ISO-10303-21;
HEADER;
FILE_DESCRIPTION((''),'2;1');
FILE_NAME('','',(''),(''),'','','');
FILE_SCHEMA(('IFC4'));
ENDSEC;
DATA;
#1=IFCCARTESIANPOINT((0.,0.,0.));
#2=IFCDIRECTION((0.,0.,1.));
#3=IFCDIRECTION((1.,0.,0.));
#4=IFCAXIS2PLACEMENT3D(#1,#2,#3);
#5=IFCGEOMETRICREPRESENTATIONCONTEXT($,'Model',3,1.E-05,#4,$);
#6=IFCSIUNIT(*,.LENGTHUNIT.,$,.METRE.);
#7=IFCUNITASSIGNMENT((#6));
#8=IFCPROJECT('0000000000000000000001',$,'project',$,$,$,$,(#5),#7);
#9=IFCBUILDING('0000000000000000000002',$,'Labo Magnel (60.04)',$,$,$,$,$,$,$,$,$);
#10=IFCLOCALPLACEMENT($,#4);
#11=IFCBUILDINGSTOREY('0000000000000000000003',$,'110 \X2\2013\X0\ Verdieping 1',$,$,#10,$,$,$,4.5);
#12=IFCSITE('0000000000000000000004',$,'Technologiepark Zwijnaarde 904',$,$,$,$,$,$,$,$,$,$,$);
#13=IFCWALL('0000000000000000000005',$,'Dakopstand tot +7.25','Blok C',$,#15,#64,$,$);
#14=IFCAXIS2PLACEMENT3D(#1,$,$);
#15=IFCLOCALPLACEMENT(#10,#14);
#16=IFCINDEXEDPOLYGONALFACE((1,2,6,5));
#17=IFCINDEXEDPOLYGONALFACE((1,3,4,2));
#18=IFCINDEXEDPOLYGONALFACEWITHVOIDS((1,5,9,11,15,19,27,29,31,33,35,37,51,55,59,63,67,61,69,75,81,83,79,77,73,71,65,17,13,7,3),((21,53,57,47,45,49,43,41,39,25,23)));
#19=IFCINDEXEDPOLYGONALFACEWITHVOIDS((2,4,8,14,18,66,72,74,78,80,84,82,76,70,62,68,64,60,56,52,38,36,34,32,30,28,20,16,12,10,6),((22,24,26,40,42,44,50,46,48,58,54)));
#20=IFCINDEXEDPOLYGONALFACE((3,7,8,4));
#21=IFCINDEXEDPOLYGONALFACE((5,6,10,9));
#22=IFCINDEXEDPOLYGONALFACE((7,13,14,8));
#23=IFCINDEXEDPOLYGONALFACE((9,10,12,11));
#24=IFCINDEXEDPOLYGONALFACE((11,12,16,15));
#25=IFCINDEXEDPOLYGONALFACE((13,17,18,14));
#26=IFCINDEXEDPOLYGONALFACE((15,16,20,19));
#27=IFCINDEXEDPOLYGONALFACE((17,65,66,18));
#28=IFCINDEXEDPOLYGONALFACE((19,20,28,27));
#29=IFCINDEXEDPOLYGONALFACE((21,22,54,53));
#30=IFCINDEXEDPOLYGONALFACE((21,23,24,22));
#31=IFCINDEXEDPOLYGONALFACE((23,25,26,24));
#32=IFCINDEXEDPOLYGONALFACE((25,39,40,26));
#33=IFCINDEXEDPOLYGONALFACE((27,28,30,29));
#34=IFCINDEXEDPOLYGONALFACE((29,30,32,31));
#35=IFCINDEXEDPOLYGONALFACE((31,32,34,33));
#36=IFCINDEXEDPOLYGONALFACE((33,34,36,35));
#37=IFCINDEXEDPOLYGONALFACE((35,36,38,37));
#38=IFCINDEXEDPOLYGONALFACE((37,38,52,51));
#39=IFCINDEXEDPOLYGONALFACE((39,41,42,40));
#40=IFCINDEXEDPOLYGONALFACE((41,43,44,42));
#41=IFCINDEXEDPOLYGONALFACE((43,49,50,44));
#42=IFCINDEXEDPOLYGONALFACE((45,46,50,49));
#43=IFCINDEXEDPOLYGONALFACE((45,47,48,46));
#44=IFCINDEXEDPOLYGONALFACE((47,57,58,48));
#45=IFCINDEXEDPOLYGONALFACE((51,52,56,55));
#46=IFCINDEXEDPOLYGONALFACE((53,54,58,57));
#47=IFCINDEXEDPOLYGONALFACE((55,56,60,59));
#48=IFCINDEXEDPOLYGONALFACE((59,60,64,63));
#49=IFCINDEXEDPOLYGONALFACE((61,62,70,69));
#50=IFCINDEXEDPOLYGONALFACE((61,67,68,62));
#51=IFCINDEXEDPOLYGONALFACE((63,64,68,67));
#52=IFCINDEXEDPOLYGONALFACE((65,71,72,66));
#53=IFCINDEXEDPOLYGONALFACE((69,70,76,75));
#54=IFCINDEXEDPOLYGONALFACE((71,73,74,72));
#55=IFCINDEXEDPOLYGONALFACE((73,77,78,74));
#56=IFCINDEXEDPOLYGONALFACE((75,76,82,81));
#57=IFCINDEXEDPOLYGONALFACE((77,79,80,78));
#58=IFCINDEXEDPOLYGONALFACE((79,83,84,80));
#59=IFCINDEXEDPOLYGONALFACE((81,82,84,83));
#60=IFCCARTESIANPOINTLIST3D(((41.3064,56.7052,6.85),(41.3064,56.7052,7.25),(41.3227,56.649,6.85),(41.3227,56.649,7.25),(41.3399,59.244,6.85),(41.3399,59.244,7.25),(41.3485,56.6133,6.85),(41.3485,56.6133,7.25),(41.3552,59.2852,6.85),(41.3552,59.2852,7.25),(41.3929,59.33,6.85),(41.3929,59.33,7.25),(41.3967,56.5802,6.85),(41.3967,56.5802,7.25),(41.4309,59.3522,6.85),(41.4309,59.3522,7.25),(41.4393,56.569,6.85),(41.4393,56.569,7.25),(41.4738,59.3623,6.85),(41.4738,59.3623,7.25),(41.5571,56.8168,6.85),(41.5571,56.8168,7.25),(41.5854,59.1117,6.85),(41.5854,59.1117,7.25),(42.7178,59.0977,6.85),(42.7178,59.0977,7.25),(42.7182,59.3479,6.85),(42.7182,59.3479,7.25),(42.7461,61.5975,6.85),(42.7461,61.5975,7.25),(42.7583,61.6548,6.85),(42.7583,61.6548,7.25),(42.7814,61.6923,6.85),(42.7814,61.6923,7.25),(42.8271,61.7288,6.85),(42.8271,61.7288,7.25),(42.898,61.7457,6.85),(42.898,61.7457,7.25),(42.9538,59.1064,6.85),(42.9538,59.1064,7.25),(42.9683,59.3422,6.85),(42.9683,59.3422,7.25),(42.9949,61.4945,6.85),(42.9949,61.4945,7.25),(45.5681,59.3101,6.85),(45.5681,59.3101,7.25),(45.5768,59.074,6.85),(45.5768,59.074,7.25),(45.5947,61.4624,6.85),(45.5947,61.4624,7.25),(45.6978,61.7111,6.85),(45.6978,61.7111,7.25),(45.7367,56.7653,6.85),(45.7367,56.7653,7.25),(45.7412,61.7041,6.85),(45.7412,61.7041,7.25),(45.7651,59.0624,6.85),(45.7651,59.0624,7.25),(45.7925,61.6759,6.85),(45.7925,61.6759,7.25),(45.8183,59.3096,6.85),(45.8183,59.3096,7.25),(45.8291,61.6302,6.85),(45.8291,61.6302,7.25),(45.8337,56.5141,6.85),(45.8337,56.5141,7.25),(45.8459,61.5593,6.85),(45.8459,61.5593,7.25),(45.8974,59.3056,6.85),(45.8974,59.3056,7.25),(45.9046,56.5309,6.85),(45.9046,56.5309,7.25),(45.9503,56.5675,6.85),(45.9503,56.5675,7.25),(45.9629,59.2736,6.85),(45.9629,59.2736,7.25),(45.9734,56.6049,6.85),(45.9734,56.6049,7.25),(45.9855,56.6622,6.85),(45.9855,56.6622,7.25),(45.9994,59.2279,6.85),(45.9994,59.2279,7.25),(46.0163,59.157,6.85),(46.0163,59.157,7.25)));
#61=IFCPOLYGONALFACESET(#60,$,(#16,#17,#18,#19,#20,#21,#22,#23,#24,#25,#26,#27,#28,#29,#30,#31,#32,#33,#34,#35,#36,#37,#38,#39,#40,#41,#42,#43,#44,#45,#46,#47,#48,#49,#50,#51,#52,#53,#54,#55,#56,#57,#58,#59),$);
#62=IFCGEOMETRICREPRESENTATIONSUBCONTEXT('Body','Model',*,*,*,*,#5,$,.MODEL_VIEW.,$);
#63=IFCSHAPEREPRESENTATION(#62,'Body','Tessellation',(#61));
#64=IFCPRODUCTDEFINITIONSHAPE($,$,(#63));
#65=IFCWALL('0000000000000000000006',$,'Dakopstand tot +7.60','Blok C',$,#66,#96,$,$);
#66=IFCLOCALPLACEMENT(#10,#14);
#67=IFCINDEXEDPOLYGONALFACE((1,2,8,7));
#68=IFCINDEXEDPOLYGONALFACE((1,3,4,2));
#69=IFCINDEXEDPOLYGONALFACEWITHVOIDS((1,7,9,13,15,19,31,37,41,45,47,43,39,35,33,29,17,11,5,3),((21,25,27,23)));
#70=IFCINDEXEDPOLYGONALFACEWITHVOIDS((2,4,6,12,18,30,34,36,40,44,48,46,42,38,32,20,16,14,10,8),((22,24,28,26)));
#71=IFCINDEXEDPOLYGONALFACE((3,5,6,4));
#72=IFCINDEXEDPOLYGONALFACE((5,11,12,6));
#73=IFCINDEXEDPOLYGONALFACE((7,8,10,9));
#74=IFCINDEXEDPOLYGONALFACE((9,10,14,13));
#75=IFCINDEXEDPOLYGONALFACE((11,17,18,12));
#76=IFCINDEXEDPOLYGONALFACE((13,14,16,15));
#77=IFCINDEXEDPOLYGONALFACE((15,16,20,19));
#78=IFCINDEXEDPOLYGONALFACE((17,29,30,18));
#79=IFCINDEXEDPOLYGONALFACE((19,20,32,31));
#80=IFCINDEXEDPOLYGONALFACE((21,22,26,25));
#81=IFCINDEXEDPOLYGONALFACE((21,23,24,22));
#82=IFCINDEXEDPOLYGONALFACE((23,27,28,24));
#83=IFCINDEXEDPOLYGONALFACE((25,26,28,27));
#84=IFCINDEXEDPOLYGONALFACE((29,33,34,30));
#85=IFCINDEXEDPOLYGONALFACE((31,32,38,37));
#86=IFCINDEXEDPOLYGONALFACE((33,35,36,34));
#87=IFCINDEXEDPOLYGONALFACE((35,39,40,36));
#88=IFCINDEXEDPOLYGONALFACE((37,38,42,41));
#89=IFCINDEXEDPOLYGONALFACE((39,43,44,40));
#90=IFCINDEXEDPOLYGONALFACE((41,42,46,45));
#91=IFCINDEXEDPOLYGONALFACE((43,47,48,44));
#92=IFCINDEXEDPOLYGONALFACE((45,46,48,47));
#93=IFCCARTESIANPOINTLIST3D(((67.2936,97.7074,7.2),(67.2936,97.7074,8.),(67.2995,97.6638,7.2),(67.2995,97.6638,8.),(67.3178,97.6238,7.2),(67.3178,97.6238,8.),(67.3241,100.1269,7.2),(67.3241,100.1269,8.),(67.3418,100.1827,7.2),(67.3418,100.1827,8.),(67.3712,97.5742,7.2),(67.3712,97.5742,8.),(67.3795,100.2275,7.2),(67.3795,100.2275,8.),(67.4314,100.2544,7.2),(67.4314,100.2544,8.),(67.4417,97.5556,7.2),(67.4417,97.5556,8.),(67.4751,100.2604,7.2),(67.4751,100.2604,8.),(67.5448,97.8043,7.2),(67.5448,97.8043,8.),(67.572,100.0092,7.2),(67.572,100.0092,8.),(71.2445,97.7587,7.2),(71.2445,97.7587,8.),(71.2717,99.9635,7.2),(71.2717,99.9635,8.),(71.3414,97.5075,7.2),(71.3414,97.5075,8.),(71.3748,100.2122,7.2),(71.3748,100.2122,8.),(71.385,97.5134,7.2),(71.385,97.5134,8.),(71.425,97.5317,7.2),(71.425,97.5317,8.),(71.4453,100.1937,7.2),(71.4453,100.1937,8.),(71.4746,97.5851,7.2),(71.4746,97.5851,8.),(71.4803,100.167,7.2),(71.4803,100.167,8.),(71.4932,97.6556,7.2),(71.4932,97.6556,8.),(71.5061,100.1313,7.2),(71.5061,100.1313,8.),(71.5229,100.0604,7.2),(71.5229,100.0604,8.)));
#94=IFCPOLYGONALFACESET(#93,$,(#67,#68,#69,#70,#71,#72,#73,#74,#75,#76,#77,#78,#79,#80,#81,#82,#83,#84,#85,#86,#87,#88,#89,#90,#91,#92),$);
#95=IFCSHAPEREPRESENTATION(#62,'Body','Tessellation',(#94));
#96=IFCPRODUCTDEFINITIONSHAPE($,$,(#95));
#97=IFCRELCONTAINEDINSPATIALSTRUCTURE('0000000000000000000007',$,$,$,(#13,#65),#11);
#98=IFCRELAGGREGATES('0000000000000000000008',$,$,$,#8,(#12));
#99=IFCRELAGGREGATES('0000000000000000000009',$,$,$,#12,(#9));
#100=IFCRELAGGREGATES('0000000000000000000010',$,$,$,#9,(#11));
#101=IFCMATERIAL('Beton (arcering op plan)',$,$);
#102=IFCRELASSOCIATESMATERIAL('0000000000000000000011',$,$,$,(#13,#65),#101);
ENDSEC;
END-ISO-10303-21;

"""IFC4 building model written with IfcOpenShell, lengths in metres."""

from ifc_helpers import new_model, si_unit, frame, origin, origin_with_axes, place, context, subcontext, project, spatial, polyline, outline, extrude, material, element, save


model = new_model("IFC4")

# Units and contexts
model_context = context("Model", 3, precision=1e-05, world=origin_with_axes())
body_context = subcontext(model_context, "Body", "Model", "MODEL_VIEW")
ifc_project = project(units=[si_unit("LENGTHUNIT", "METRE")], contexts=[model_context])

# Site, building, storey
site = spatial("IfcSite", under=ifc_project, Name="Technologiepark Zwijnaarde 904")
building = spatial("IfcBuilding", under=site, Name="Labo Magnel (60.04)")
storey_placement = place(None, origin_with_axes())
storey = spatial("IfcBuildingStorey", under=building, at=storey_placement, Name="110 – Verdieping 1", Elevation=4.5)

# Shared definitions
ifc_material_1 = material(Name="Beton (arcering op plan)")

# Walls
wall_1_placement = place(storey_placement, frame((0.0, 0.0, 6.85), z_axis=(0.0, 0.0, 1.0), x_axis=(1.0, 0.0, 0.0)))
element("IfcWall", 1, at=wall_1_placement, inside=storey, material=ifc_material_1, Name="Dakopstand tot +7.25", Description="Blok C", context=body_context, shape_type="SweptSolid", body=[
    extrude(outline(polyline([(41.4393, 56.569), (41.3967, 56.5802), (41.3485, 56.6133), (41.3227, 56.649), (41.3064, 56.7052), (41.3399, 59.244), (41.3552, 59.2852), (41.3929, 59.33), (41.4309, 59.3522), (41.4738, 59.3623), (42.7182, 59.3479), (42.7461, 61.5975), (42.7583, 61.6548), (42.7814, 61.6923), (42.8271, 61.7288), (42.898, 61.7457), (45.6978, 61.7111), (45.7412, 61.7041), (45.7925, 61.6759), (45.8291, 61.6302), (45.8459, 61.5593), (45.8183, 59.3096), (45.8974, 59.3056), (45.9629, 59.2736), (45.9994, 59.2279), (46.0163, 59.157), (45.9855, 56.6622), (45.9734, 56.6049), (45.9503, 56.5675), (45.9046, 56.5309), (45.8337, 56.5141), (41.4393, 56.569)]), holes=[polyline([(41.5571, 56.8168), (45.7367, 56.7653), (45.7651, 59.0624), (45.5768, 59.074), (45.5681, 59.3101), (45.5947, 61.4624), (42.9949, 61.4945), (42.9683, 59.3422), (42.9538, 59.1064), (42.7178, 59.0977), (41.5854, 59.1117), (41.5571, 56.8168)])]), origin(), (0.0, 0.0, 1.0), 0.4),
])
wall_2_placement = place(storey_placement, frame((0.0, 0.0, 7.2), z_axis=(0.0, 0.0, 1.0), x_axis=(1.0, 0.0, 0.0)))
element("IfcWall", 2, at=wall_2_placement, inside=storey, material=ifc_material_1, Name="Dakopstand tot +7.60", Description="Blok C", context=body_context, shape_type="SweptSolid", body=[
    extrude(outline(polyline([(67.3241, 100.1269), (67.3418, 100.1827), (67.3795, 100.2275), (67.4314, 100.2544), (67.4751, 100.2604), (71.3748, 100.2122), (71.4453, 100.1937), (71.4803, 100.167), (71.5061, 100.1313), (71.5229, 100.0604), (71.4932, 97.6556), (71.4746, 97.5851), (71.425, 97.5317), (71.385, 97.5134), (71.3414, 97.5075), (67.4417, 97.5556), (67.3712, 97.5742), (67.3178, 97.6238), (67.2995, 97.6638), (67.2936, 97.7074), (67.3241, 100.1269)]), holes=[polyline([(71.2445, 97.7587), (71.2717, 99.9635), (67.572, 100.0092), (67.5448, 97.8043), (71.2445, 97.7587)])]), origin(), (0.0, 0.0, 1.0), 0.8),
])

save(model, "model.ifc")
